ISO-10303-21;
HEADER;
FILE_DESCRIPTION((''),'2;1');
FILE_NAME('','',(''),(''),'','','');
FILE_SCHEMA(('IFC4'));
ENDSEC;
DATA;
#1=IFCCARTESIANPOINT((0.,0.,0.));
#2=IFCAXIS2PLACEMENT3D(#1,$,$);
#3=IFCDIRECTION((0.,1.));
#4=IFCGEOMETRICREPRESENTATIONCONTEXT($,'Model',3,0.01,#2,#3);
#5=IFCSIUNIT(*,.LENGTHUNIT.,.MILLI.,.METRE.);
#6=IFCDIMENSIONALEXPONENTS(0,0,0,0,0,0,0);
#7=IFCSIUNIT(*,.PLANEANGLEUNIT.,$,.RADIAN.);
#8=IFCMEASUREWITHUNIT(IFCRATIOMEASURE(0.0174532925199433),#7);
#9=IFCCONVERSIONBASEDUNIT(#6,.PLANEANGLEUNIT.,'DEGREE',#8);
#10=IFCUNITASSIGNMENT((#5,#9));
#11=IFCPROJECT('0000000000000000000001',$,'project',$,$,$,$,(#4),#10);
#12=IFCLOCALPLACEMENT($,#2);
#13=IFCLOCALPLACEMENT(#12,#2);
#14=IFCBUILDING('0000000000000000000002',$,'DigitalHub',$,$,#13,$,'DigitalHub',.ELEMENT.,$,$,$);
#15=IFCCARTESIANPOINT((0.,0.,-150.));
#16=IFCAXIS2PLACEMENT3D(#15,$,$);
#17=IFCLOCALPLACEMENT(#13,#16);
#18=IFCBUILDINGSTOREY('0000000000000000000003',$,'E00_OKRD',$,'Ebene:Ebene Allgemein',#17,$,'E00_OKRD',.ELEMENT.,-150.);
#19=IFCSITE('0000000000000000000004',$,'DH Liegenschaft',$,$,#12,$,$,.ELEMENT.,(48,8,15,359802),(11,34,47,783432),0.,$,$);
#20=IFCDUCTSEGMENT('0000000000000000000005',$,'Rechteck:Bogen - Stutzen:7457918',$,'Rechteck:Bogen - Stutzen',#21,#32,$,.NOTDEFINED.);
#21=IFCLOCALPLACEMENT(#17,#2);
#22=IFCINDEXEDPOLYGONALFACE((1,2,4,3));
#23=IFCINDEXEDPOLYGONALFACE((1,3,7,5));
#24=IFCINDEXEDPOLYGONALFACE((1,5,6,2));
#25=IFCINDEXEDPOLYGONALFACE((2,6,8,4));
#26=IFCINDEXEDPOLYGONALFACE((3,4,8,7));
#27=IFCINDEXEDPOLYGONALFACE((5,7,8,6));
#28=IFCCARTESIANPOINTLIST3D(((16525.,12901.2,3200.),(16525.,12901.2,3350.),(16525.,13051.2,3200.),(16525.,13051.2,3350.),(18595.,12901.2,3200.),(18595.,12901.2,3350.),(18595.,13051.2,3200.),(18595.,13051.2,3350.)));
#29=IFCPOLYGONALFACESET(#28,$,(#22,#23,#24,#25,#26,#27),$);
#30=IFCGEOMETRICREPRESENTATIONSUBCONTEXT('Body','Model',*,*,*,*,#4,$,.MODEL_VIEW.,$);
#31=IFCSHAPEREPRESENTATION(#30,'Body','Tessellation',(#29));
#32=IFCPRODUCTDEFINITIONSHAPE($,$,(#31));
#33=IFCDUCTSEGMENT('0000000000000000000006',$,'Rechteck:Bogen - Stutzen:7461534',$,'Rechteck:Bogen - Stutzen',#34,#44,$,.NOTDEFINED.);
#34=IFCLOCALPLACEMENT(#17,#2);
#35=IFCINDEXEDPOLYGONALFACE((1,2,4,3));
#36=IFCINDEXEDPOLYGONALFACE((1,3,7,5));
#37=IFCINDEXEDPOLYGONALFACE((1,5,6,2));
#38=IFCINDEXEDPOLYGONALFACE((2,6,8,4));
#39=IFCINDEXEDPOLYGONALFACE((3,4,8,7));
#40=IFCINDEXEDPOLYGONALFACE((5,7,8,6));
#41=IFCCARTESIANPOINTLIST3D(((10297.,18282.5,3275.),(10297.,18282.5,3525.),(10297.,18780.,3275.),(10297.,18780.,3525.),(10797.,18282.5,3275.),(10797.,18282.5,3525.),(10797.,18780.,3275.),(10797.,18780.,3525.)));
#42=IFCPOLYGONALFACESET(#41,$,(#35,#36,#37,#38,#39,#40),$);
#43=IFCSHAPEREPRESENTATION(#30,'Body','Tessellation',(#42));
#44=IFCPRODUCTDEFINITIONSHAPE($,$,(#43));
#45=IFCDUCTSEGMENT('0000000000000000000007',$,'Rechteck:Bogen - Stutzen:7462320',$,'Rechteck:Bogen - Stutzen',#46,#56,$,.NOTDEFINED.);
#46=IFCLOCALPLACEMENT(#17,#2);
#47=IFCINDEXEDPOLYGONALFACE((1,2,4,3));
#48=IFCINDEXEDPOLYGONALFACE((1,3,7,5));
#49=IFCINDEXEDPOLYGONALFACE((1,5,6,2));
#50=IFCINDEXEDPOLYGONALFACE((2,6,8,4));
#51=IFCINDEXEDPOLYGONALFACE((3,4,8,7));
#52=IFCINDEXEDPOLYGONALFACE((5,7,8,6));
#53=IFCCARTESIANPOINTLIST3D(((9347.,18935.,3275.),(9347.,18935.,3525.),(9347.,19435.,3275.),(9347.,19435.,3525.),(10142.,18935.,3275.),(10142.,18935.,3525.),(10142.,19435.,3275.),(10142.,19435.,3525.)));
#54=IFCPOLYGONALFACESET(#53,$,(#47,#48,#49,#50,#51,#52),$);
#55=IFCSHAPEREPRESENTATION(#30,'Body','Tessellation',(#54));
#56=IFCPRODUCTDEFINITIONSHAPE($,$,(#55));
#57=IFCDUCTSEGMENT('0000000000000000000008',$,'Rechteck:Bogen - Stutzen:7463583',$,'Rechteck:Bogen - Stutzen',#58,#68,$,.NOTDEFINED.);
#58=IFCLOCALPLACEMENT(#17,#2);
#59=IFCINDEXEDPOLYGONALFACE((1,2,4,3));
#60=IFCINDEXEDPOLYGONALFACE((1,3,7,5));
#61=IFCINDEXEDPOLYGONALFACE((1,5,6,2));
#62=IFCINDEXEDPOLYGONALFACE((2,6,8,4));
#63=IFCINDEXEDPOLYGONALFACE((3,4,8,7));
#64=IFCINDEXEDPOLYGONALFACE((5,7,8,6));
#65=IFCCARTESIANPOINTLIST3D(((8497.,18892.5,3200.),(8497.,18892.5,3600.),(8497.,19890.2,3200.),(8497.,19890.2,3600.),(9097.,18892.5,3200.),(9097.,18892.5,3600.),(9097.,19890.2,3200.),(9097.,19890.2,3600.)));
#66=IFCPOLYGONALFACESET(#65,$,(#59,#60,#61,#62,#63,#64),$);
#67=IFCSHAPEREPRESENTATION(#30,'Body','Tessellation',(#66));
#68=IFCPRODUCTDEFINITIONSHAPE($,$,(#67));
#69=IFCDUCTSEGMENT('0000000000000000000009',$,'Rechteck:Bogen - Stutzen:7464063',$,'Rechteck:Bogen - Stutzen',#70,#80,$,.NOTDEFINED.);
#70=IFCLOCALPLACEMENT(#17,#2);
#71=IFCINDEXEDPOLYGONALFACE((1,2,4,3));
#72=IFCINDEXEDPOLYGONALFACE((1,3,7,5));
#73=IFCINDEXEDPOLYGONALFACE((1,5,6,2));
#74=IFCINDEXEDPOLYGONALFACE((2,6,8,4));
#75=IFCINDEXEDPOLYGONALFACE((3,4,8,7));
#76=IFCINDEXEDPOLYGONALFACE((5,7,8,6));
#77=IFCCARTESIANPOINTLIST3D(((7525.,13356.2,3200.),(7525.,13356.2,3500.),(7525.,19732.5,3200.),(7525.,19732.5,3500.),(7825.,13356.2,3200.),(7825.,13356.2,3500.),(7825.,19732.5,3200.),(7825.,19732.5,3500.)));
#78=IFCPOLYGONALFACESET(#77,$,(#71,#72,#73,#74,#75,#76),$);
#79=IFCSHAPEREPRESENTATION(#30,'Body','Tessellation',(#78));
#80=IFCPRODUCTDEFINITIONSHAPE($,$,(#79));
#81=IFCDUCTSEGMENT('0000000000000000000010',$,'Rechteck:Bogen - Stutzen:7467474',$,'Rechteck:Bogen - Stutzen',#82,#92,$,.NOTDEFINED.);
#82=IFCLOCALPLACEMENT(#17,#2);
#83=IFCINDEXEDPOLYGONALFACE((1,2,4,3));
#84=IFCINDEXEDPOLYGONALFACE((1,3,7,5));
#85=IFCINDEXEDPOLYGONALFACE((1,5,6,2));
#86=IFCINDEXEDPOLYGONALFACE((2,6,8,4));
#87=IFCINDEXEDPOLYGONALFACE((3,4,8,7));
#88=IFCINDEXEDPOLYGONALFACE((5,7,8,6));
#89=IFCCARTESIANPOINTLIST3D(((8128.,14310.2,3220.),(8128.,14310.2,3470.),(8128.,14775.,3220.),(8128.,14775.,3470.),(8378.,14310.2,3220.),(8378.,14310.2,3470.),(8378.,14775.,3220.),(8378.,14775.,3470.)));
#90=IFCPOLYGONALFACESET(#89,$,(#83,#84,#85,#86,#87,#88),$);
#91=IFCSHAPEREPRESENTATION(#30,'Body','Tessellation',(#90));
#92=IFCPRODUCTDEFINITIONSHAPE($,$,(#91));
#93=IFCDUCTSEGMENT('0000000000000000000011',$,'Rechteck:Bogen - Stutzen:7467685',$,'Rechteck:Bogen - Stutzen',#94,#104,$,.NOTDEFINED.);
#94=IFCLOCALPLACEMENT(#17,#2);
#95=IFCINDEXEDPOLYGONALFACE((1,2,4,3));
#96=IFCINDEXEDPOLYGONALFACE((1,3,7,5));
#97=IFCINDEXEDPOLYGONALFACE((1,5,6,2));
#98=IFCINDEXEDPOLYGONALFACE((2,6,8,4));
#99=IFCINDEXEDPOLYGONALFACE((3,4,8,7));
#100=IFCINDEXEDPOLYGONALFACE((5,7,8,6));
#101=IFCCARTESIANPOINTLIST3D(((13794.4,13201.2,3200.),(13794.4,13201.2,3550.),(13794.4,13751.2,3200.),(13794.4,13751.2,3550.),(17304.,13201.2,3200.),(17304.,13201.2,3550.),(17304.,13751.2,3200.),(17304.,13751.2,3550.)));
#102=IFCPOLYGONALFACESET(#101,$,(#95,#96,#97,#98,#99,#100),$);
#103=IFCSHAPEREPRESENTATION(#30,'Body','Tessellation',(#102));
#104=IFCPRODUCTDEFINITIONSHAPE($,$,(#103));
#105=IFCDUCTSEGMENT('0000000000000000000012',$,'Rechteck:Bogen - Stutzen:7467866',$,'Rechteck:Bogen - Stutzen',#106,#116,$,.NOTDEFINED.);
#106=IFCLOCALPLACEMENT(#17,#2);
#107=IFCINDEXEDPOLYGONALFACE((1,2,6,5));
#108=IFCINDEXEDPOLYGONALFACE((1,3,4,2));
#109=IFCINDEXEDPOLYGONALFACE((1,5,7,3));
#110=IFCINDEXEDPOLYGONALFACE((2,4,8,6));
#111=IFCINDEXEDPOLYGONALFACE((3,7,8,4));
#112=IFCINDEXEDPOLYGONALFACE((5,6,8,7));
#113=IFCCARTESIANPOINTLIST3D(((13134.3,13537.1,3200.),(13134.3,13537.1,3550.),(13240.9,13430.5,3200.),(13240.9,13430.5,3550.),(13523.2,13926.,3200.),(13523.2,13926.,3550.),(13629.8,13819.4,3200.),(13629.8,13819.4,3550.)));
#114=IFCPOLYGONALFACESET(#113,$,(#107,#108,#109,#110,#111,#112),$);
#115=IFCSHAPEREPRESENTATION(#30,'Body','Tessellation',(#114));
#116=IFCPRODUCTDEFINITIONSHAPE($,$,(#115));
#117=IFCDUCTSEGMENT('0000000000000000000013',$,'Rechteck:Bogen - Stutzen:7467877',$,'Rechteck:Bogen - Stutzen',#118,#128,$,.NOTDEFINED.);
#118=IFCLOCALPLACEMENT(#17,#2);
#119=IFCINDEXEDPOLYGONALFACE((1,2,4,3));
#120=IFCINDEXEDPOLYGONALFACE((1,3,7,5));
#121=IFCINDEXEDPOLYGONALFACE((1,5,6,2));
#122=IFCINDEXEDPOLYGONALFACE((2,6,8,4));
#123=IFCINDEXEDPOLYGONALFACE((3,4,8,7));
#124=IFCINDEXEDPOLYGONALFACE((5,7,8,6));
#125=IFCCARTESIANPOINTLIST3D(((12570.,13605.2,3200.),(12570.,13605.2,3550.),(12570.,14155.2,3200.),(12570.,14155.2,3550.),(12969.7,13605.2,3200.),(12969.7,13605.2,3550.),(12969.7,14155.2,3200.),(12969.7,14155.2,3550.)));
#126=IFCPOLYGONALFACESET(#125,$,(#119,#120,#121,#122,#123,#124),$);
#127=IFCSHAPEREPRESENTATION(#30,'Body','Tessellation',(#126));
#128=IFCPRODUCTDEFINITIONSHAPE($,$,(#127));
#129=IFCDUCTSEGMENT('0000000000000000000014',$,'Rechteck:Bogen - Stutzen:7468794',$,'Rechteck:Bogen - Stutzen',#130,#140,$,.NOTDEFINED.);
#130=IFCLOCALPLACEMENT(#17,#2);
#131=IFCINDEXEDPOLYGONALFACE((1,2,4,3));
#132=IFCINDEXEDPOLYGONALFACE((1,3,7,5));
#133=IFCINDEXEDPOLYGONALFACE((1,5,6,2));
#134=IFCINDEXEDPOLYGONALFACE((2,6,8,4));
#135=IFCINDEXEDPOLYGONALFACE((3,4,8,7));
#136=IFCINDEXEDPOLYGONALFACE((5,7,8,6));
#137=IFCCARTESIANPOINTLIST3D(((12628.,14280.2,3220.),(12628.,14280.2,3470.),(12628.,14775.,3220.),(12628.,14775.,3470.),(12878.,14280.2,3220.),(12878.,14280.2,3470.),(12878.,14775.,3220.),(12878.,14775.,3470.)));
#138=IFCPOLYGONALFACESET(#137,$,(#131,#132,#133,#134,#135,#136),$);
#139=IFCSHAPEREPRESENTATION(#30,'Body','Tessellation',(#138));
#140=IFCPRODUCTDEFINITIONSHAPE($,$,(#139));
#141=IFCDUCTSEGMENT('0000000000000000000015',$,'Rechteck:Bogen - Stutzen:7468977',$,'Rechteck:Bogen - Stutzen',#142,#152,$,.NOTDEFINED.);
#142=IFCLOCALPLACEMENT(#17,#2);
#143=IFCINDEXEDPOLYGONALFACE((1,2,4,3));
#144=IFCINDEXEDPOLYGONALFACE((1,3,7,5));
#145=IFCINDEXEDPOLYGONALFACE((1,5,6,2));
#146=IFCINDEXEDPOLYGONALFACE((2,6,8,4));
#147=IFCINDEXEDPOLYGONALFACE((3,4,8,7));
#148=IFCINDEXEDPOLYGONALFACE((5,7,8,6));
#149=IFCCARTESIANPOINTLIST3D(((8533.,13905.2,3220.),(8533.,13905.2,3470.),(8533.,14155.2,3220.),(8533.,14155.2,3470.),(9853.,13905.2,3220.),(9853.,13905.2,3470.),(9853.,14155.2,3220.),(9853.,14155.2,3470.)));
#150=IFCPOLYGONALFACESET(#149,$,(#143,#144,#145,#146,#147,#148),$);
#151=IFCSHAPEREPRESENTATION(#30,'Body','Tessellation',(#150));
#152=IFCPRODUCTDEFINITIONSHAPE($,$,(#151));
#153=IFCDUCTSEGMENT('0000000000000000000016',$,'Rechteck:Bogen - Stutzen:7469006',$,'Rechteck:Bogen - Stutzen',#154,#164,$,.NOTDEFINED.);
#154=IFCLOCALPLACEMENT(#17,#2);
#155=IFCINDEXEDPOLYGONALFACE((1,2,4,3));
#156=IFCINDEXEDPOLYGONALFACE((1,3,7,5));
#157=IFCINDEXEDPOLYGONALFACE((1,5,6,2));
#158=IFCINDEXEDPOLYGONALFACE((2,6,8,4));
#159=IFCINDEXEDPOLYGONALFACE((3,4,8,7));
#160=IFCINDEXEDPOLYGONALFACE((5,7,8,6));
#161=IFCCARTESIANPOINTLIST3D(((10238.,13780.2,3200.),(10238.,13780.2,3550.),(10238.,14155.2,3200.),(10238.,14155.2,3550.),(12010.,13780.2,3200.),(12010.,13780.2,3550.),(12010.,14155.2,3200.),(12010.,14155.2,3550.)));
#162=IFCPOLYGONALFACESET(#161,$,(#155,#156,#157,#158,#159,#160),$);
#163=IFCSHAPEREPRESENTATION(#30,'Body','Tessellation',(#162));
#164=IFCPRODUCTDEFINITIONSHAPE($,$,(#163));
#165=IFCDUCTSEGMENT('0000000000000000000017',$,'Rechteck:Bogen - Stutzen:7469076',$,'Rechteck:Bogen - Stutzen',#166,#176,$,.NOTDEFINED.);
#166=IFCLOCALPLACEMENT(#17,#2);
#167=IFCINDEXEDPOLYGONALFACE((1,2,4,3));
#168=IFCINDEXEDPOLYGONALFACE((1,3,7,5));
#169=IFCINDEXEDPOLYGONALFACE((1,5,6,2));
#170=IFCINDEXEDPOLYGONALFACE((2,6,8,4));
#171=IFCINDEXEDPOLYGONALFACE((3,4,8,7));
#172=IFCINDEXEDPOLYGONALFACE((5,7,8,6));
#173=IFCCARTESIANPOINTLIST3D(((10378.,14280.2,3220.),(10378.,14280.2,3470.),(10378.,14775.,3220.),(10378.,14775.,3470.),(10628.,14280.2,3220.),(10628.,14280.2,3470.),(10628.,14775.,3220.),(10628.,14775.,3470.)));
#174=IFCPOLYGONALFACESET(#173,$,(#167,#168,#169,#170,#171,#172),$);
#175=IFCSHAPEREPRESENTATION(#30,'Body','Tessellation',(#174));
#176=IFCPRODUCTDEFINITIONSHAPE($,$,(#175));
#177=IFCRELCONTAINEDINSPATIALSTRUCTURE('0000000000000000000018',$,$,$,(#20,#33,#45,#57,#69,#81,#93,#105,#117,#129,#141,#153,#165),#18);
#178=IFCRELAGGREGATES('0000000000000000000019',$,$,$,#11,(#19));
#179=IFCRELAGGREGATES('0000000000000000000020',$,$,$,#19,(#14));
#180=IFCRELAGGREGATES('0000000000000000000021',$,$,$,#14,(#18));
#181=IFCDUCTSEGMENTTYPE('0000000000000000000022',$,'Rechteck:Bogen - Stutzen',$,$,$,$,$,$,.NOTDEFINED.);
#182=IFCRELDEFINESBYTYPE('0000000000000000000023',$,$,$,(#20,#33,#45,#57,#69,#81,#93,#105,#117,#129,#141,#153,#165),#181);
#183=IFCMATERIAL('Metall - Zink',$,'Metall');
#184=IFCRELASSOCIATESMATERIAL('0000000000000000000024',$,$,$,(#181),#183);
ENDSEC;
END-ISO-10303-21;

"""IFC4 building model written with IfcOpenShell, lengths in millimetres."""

from ifc_helpers import new_model, entity, si_unit, converted_unit, direction, frame, origin, place, context, subcontext, project, spatial, indexed_curve, outline, extrude, material, type_object, element, save


model = new_model("IFC4")

# Units and contexts
model_context = context("Model", 3, precision=0.01, world=origin(), true_north=direction((0.0, 1.0)))
body_context = subcontext(model_context, "Body", "Model", "MODEL_VIEW")
ifc_project = project(units=[si_unit("LENGTHUNIT", "METRE", prefix="MILLI"), converted_unit("PLANEANGLEUNIT", "DEGREE", entity("IfcRatioMeasure", 0.0174532925199433), si_unit("PLANEANGLEUNIT", "RADIAN"), dimensions=[0, 0, 0, 0, 0, 0, 0])], contexts=[model_context])

# Site, building, storey
site_placement = place(None, origin())
site = spatial("IfcSite", under=ifc_project, at=site_placement, Name="DH Liegenschaft", CompositionType="ELEMENT", RefLatitude=(48, 8, 15, 359802), RefLongitude=(11, 34, 47, 783432), RefElevation=0.0)
building_placement = place(site_placement, origin())
building = spatial("IfcBuilding", under=site, at=building_placement, Name="DigitalHub", LongName="DigitalHub", CompositionType="ELEMENT")
storey_placement = place(building_placement, frame((0.0, 0.0, -150.0)))
storey = spatial("IfcBuildingStorey", under=building, at=storey_placement, Name="E00_OKRD", ObjectType="Ebene:Ebene Allgemein", LongName="E00_OKRD", CompositionType="ELEMENT", Elevation=-150.0)

# Duct segments
ifc_material_1 = material(Name="Metall - Zink", Category="Metall")
duct_segment_type = type_object("IfcDuctSegmentType", Name="Rechteck:Bogen - Stutzen", PredefinedType="NOTDEFINED", material=ifc_material_1)
duct_segment_1_placement = place(storey_placement, frame((16525.0, 12901.2, 3200.0)))
element("IfcDuctSegment", 1, at=duct_segment_1_placement, inside=storey, type_object=duct_segment_type, Name="Rechteck:Bogen - Stutzen:7457918", ObjectType="Rechteck:Bogen - Stutzen", PredefinedType="NOTDEFINED", context=body_context, shape_type="SweptSolid", body=[
    extrude(outline(indexed_curve([(-1035.0, -75.0), (1035.0, -75.0), (1035.0, 75.0), (-1035.0, 75.0), (-1035.0, -75.0)], self_intersect=False)), frame((1035.0, 75.0, 0.0), z_axis=(0.0, 0.0, 1.0), x_axis=(-1.0, 0.0, 0.0)), (0.0, 0.0, 1.0), 150.0),
])
duct_segment_2_placement = place(storey_placement, frame((10297.0, 18282.5, 3275.0)))
element("IfcDuctSegment", 2, at=duct_segment_2_placement, inside=storey, type_object=duct_segment_type, Name="Rechteck:Bogen - Stutzen:7461534", ObjectType="Rechteck:Bogen - Stutzen", PredefinedType="NOTDEFINED", context=body_context, shape_type="SweptSolid", body=[
    extrude(outline(indexed_curve([(-248.7, -250.0), (248.7, -250.0), (248.7, 250.0), (-248.7, 250.0), (-248.7, -250.0)], self_intersect=False)), frame((250.0, 248.7, 0.0), z_axis=(0.0, 0.0, 1.0), x_axis=(0.0, 1.0, 0.0)), (0.0, 0.0, 1.0), 250.0),
])
duct_segment_3_placement = place(storey_placement, frame((9347.0, 18935.0, 3275.0)))
element("IfcDuctSegment", 3, at=duct_segment_3_placement, inside=storey, type_object=duct_segment_type, Name="Rechteck:Bogen - Stutzen:7462320", ObjectType="Rechteck:Bogen - Stutzen", PredefinedType="NOTDEFINED", context=body_context, shape_type="SweptSolid", body=[
    extrude(outline(indexed_curve([(-397.5, -250.0), (397.5, -250.0), (397.5, 250.0), (-397.5, 250.0), (-397.5, -250.0)], self_intersect=False)), frame((397.5, 250.0, 0.0), z_axis=(0.0, 0.0, 1.0), x_axis=(-1.0, 0.0, 0.0)), (0.0, 0.0, 1.0), 250.0),
])
duct_segment_4_placement = place(storey_placement, frame((8497.0, 18892.5, 3200.0)))
element("IfcDuctSegment", 4, at=duct_segment_4_placement, inside=storey, type_object=duct_segment_type, Name="Rechteck:Bogen - Stutzen:7463583", ObjectType="Rechteck:Bogen - Stutzen", PredefinedType="NOTDEFINED", context=body_context, shape_type="SweptSolid", body=[
    extrude(outline(indexed_curve([(-498.8, -300.0), (498.8, -300.0), (498.8, 300.0), (-498.8, 300.0), (-498.8, -300.0)], self_intersect=False)), frame((300.0, 498.8, 0.0), z_axis=(0.0, 0.0, 1.0), x_axis=(0.0, 1.0, 0.0)), (0.0, 0.0, 1.0), 400.0),
])
duct_segment_5_placement = place(storey_placement, frame((7525.0, 13356.2, 3200.0)))
element("IfcDuctSegment", 5, at=duct_segment_5_placement, inside=storey, type_object=duct_segment_type, Name="Rechteck:Bogen - Stutzen:7464063", ObjectType="Rechteck:Bogen - Stutzen", PredefinedType="NOTDEFINED", context=body_context, shape_type="SweptSolid", body=[
    extrude(outline(indexed_curve([(-3188.1, -150.0), (3188.1, -150.0), (3188.1, 150.0), (-3188.1, 150.0), (-3188.1, -150.0)], self_intersect=False)), frame((150.0, 3188.1, 0.0), z_axis=(0.0, 0.0, 1.0), x_axis=(0.0, 1.0, 0.0)), (0.0, 0.0, 1.0), 300.0),
])
duct_segment_6_placement = place(storey_placement, frame((8128.0, 14310.2, 3220.0)))
element("IfcDuctSegment", 6, at=duct_segment_6_placement, inside=storey, type_object=duct_segment_type, Name="Rechteck:Bogen - Stutzen:7467474", ObjectType="Rechteck:Bogen - Stutzen", PredefinedType="NOTDEFINED", context=body_context, shape_type="SweptSolid", body=[
    extrude(outline(indexed_curve([(-232.4, -125.0), (232.4, -125.0), (232.4, 125.0), (-232.4, 125.0), (-232.4, -125.0)], self_intersect=False)), frame((125.0, 232.4, 0.0), z_axis=(0.0, 0.0, 1.0), x_axis=(0.0, -1.0, 0.0)), (0.0, 0.0, 1.0), 250.0),
])
duct_segment_7_placement = place(storey_placement, frame((13794.4, 13201.2, 3200.0)))
element("IfcDuctSegment", 7, at=duct_segment_7_placement, inside=storey, type_object=duct_segment_type, Name="Rechteck:Bogen - Stutzen:7467685", ObjectType="Rechteck:Bogen - Stutzen", PredefinedType="NOTDEFINED", context=body_context, shape_type="SweptSolid", body=[
    extrude(outline(indexed_curve([(-1754.8, -275.0), (1754.8, -275.0), (1754.8, 275.0), (-1754.8, 275.0), (-1754.8, -275.0)], self_intersect=False)), frame((1754.8, 275.0, 0.0)), (0.0, 0.0, 1.0), 350.0),
])
duct_segment_8_placement = place(storey_placement, frame((13134.3, 13430.5, 3200.0)))
element("IfcDuctSegment", 8, at=duct_segment_8_placement, inside=storey, type_object=duct_segment_type, Name="Rechteck:Bogen - Stutzen:7467866", ObjectType="Rechteck:Bogen - Stutzen", PredefinedType="NOTDEFINED", context=body_context, shape_type="SweptSolid", body=[
    extrude(outline(indexed_curve([(-75.4, -275.0), (75.4, -275.0), (75.4, 275.0), (-75.4, 275.0), (-75.4, -275.0)], self_intersect=False)), frame((247.7, 247.7, 0.0), z_axis=(0.0, 0.0, 1.0), x_axis=(-0.707107, 0.707107, 0.0)), (0.0, 0.0, 1.0), 350.0),
])
duct_segment_9_placement = place(storey_placement, frame((12570.0, 13605.2, 3200.0)))
element("IfcDuctSegment", 9, at=duct_segment_9_placement, inside=storey, type_object=duct_segment_type, Name="Rechteck:Bogen - Stutzen:7467877", ObjectType="Rechteck:Bogen - Stutzen", PredefinedType="NOTDEFINED", context=body_context, shape_type="SweptSolid", body=[
    extrude(outline(indexed_curve([(-199.8, -275.0), (199.8, -275.0), (199.8, 275.0), (-199.8, 275.0), (-199.8, -275.0)], self_intersect=False)), frame((199.8, 275.0, 0.0), z_axis=(0.0, 0.0, 1.0), x_axis=(-1.0, 0.0, 0.0)), (0.0, 0.0, 1.0), 350.0),
])
duct_segment_10_placement = place(storey_placement, frame((12628.0, 14280.2, 3220.0)))
element("IfcDuctSegment", 10, at=duct_segment_10_placement, inside=storey, type_object=duct_segment_type, Name="Rechteck:Bogen - Stutzen:7468794", ObjectType="Rechteck:Bogen - Stutzen", PredefinedType="NOTDEFINED", context=body_context, shape_type="SweptSolid", body=[
    extrude(outline(indexed_curve([(-247.4, -125.0), (247.4, -125.0), (247.4, 125.0), (-247.4, 125.0), (-247.4, -125.0)], self_intersect=False)), frame((125.0, 247.4, 0.0), z_axis=(0.0, 0.0, 1.0), x_axis=(0.0, 1.0, 0.0)), (0.0, 0.0, 1.0), 250.0),
])
duct_segment_11_placement = place(storey_placement, frame((8533.0, 13905.2, 3220.0)))
element("IfcDuctSegment", 11, at=duct_segment_11_placement, inside=storey, type_object=duct_segment_type, Name="Rechteck:Bogen - Stutzen:7468977", ObjectType="Rechteck:Bogen - Stutzen", PredefinedType="NOTDEFINED", context=body_context, shape_type="SweptSolid", body=[
    extrude(outline(indexed_curve([(-660.0, -125.0), (660.0, -125.0), (660.0, 125.0), (-660.0, 125.0), (-660.0, -125.0)], self_intersect=False)), frame((660.0, 125.0, 0.0)), (0.0, 0.0, 1.0), 250.0),
])
duct_segment_12_placement = place(storey_placement, frame((10238.0, 13780.2, 3200.0)))
element("IfcDuctSegment", 12, at=duct_segment_12_placement, inside=storey, type_object=duct_segment_type, Name="Rechteck:Bogen - Stutzen:7469006", ObjectType="Rechteck:Bogen - Stutzen", PredefinedType="NOTDEFINED", context=body_context, shape_type="SweptSolid", body=[
    extrude(outline(indexed_curve([(-886.0, -187.5), (886.0, -187.5), (886.0, 187.5), (-886.0, 187.5), (-886.0, -187.5)], self_intersect=False)), frame((886.0, 187.5, 0.0)), (0.0, 0.0, 1.0), 350.0),
])
duct_segment_13_placement = place(storey_placement, frame((10378.0, 14280.2, 3220.0)))
element("IfcDuctSegment", 13, at=duct_segment_13_placement, inside=storey, type_object=duct_segment_type, Name="Rechteck:Bogen - Stutzen:7469076", ObjectType="Rechteck:Bogen - Stutzen", PredefinedType="NOTDEFINED", context=body_context, shape_type="SweptSolid", body=[
    extrude(outline(indexed_curve([(-247.4, -125.0), (247.4, -125.0), (247.4, 125.0), (-247.4, 125.0), (-247.4, -125.0)], self_intersect=False)), frame((125.0, 247.4, 0.0), z_axis=(0.0, 0.0, 1.0), x_axis=(0.0, 1.0, 0.0)), (0.0, 0.0, 1.0), 250.0),
])

save(model, "model.ifc")
